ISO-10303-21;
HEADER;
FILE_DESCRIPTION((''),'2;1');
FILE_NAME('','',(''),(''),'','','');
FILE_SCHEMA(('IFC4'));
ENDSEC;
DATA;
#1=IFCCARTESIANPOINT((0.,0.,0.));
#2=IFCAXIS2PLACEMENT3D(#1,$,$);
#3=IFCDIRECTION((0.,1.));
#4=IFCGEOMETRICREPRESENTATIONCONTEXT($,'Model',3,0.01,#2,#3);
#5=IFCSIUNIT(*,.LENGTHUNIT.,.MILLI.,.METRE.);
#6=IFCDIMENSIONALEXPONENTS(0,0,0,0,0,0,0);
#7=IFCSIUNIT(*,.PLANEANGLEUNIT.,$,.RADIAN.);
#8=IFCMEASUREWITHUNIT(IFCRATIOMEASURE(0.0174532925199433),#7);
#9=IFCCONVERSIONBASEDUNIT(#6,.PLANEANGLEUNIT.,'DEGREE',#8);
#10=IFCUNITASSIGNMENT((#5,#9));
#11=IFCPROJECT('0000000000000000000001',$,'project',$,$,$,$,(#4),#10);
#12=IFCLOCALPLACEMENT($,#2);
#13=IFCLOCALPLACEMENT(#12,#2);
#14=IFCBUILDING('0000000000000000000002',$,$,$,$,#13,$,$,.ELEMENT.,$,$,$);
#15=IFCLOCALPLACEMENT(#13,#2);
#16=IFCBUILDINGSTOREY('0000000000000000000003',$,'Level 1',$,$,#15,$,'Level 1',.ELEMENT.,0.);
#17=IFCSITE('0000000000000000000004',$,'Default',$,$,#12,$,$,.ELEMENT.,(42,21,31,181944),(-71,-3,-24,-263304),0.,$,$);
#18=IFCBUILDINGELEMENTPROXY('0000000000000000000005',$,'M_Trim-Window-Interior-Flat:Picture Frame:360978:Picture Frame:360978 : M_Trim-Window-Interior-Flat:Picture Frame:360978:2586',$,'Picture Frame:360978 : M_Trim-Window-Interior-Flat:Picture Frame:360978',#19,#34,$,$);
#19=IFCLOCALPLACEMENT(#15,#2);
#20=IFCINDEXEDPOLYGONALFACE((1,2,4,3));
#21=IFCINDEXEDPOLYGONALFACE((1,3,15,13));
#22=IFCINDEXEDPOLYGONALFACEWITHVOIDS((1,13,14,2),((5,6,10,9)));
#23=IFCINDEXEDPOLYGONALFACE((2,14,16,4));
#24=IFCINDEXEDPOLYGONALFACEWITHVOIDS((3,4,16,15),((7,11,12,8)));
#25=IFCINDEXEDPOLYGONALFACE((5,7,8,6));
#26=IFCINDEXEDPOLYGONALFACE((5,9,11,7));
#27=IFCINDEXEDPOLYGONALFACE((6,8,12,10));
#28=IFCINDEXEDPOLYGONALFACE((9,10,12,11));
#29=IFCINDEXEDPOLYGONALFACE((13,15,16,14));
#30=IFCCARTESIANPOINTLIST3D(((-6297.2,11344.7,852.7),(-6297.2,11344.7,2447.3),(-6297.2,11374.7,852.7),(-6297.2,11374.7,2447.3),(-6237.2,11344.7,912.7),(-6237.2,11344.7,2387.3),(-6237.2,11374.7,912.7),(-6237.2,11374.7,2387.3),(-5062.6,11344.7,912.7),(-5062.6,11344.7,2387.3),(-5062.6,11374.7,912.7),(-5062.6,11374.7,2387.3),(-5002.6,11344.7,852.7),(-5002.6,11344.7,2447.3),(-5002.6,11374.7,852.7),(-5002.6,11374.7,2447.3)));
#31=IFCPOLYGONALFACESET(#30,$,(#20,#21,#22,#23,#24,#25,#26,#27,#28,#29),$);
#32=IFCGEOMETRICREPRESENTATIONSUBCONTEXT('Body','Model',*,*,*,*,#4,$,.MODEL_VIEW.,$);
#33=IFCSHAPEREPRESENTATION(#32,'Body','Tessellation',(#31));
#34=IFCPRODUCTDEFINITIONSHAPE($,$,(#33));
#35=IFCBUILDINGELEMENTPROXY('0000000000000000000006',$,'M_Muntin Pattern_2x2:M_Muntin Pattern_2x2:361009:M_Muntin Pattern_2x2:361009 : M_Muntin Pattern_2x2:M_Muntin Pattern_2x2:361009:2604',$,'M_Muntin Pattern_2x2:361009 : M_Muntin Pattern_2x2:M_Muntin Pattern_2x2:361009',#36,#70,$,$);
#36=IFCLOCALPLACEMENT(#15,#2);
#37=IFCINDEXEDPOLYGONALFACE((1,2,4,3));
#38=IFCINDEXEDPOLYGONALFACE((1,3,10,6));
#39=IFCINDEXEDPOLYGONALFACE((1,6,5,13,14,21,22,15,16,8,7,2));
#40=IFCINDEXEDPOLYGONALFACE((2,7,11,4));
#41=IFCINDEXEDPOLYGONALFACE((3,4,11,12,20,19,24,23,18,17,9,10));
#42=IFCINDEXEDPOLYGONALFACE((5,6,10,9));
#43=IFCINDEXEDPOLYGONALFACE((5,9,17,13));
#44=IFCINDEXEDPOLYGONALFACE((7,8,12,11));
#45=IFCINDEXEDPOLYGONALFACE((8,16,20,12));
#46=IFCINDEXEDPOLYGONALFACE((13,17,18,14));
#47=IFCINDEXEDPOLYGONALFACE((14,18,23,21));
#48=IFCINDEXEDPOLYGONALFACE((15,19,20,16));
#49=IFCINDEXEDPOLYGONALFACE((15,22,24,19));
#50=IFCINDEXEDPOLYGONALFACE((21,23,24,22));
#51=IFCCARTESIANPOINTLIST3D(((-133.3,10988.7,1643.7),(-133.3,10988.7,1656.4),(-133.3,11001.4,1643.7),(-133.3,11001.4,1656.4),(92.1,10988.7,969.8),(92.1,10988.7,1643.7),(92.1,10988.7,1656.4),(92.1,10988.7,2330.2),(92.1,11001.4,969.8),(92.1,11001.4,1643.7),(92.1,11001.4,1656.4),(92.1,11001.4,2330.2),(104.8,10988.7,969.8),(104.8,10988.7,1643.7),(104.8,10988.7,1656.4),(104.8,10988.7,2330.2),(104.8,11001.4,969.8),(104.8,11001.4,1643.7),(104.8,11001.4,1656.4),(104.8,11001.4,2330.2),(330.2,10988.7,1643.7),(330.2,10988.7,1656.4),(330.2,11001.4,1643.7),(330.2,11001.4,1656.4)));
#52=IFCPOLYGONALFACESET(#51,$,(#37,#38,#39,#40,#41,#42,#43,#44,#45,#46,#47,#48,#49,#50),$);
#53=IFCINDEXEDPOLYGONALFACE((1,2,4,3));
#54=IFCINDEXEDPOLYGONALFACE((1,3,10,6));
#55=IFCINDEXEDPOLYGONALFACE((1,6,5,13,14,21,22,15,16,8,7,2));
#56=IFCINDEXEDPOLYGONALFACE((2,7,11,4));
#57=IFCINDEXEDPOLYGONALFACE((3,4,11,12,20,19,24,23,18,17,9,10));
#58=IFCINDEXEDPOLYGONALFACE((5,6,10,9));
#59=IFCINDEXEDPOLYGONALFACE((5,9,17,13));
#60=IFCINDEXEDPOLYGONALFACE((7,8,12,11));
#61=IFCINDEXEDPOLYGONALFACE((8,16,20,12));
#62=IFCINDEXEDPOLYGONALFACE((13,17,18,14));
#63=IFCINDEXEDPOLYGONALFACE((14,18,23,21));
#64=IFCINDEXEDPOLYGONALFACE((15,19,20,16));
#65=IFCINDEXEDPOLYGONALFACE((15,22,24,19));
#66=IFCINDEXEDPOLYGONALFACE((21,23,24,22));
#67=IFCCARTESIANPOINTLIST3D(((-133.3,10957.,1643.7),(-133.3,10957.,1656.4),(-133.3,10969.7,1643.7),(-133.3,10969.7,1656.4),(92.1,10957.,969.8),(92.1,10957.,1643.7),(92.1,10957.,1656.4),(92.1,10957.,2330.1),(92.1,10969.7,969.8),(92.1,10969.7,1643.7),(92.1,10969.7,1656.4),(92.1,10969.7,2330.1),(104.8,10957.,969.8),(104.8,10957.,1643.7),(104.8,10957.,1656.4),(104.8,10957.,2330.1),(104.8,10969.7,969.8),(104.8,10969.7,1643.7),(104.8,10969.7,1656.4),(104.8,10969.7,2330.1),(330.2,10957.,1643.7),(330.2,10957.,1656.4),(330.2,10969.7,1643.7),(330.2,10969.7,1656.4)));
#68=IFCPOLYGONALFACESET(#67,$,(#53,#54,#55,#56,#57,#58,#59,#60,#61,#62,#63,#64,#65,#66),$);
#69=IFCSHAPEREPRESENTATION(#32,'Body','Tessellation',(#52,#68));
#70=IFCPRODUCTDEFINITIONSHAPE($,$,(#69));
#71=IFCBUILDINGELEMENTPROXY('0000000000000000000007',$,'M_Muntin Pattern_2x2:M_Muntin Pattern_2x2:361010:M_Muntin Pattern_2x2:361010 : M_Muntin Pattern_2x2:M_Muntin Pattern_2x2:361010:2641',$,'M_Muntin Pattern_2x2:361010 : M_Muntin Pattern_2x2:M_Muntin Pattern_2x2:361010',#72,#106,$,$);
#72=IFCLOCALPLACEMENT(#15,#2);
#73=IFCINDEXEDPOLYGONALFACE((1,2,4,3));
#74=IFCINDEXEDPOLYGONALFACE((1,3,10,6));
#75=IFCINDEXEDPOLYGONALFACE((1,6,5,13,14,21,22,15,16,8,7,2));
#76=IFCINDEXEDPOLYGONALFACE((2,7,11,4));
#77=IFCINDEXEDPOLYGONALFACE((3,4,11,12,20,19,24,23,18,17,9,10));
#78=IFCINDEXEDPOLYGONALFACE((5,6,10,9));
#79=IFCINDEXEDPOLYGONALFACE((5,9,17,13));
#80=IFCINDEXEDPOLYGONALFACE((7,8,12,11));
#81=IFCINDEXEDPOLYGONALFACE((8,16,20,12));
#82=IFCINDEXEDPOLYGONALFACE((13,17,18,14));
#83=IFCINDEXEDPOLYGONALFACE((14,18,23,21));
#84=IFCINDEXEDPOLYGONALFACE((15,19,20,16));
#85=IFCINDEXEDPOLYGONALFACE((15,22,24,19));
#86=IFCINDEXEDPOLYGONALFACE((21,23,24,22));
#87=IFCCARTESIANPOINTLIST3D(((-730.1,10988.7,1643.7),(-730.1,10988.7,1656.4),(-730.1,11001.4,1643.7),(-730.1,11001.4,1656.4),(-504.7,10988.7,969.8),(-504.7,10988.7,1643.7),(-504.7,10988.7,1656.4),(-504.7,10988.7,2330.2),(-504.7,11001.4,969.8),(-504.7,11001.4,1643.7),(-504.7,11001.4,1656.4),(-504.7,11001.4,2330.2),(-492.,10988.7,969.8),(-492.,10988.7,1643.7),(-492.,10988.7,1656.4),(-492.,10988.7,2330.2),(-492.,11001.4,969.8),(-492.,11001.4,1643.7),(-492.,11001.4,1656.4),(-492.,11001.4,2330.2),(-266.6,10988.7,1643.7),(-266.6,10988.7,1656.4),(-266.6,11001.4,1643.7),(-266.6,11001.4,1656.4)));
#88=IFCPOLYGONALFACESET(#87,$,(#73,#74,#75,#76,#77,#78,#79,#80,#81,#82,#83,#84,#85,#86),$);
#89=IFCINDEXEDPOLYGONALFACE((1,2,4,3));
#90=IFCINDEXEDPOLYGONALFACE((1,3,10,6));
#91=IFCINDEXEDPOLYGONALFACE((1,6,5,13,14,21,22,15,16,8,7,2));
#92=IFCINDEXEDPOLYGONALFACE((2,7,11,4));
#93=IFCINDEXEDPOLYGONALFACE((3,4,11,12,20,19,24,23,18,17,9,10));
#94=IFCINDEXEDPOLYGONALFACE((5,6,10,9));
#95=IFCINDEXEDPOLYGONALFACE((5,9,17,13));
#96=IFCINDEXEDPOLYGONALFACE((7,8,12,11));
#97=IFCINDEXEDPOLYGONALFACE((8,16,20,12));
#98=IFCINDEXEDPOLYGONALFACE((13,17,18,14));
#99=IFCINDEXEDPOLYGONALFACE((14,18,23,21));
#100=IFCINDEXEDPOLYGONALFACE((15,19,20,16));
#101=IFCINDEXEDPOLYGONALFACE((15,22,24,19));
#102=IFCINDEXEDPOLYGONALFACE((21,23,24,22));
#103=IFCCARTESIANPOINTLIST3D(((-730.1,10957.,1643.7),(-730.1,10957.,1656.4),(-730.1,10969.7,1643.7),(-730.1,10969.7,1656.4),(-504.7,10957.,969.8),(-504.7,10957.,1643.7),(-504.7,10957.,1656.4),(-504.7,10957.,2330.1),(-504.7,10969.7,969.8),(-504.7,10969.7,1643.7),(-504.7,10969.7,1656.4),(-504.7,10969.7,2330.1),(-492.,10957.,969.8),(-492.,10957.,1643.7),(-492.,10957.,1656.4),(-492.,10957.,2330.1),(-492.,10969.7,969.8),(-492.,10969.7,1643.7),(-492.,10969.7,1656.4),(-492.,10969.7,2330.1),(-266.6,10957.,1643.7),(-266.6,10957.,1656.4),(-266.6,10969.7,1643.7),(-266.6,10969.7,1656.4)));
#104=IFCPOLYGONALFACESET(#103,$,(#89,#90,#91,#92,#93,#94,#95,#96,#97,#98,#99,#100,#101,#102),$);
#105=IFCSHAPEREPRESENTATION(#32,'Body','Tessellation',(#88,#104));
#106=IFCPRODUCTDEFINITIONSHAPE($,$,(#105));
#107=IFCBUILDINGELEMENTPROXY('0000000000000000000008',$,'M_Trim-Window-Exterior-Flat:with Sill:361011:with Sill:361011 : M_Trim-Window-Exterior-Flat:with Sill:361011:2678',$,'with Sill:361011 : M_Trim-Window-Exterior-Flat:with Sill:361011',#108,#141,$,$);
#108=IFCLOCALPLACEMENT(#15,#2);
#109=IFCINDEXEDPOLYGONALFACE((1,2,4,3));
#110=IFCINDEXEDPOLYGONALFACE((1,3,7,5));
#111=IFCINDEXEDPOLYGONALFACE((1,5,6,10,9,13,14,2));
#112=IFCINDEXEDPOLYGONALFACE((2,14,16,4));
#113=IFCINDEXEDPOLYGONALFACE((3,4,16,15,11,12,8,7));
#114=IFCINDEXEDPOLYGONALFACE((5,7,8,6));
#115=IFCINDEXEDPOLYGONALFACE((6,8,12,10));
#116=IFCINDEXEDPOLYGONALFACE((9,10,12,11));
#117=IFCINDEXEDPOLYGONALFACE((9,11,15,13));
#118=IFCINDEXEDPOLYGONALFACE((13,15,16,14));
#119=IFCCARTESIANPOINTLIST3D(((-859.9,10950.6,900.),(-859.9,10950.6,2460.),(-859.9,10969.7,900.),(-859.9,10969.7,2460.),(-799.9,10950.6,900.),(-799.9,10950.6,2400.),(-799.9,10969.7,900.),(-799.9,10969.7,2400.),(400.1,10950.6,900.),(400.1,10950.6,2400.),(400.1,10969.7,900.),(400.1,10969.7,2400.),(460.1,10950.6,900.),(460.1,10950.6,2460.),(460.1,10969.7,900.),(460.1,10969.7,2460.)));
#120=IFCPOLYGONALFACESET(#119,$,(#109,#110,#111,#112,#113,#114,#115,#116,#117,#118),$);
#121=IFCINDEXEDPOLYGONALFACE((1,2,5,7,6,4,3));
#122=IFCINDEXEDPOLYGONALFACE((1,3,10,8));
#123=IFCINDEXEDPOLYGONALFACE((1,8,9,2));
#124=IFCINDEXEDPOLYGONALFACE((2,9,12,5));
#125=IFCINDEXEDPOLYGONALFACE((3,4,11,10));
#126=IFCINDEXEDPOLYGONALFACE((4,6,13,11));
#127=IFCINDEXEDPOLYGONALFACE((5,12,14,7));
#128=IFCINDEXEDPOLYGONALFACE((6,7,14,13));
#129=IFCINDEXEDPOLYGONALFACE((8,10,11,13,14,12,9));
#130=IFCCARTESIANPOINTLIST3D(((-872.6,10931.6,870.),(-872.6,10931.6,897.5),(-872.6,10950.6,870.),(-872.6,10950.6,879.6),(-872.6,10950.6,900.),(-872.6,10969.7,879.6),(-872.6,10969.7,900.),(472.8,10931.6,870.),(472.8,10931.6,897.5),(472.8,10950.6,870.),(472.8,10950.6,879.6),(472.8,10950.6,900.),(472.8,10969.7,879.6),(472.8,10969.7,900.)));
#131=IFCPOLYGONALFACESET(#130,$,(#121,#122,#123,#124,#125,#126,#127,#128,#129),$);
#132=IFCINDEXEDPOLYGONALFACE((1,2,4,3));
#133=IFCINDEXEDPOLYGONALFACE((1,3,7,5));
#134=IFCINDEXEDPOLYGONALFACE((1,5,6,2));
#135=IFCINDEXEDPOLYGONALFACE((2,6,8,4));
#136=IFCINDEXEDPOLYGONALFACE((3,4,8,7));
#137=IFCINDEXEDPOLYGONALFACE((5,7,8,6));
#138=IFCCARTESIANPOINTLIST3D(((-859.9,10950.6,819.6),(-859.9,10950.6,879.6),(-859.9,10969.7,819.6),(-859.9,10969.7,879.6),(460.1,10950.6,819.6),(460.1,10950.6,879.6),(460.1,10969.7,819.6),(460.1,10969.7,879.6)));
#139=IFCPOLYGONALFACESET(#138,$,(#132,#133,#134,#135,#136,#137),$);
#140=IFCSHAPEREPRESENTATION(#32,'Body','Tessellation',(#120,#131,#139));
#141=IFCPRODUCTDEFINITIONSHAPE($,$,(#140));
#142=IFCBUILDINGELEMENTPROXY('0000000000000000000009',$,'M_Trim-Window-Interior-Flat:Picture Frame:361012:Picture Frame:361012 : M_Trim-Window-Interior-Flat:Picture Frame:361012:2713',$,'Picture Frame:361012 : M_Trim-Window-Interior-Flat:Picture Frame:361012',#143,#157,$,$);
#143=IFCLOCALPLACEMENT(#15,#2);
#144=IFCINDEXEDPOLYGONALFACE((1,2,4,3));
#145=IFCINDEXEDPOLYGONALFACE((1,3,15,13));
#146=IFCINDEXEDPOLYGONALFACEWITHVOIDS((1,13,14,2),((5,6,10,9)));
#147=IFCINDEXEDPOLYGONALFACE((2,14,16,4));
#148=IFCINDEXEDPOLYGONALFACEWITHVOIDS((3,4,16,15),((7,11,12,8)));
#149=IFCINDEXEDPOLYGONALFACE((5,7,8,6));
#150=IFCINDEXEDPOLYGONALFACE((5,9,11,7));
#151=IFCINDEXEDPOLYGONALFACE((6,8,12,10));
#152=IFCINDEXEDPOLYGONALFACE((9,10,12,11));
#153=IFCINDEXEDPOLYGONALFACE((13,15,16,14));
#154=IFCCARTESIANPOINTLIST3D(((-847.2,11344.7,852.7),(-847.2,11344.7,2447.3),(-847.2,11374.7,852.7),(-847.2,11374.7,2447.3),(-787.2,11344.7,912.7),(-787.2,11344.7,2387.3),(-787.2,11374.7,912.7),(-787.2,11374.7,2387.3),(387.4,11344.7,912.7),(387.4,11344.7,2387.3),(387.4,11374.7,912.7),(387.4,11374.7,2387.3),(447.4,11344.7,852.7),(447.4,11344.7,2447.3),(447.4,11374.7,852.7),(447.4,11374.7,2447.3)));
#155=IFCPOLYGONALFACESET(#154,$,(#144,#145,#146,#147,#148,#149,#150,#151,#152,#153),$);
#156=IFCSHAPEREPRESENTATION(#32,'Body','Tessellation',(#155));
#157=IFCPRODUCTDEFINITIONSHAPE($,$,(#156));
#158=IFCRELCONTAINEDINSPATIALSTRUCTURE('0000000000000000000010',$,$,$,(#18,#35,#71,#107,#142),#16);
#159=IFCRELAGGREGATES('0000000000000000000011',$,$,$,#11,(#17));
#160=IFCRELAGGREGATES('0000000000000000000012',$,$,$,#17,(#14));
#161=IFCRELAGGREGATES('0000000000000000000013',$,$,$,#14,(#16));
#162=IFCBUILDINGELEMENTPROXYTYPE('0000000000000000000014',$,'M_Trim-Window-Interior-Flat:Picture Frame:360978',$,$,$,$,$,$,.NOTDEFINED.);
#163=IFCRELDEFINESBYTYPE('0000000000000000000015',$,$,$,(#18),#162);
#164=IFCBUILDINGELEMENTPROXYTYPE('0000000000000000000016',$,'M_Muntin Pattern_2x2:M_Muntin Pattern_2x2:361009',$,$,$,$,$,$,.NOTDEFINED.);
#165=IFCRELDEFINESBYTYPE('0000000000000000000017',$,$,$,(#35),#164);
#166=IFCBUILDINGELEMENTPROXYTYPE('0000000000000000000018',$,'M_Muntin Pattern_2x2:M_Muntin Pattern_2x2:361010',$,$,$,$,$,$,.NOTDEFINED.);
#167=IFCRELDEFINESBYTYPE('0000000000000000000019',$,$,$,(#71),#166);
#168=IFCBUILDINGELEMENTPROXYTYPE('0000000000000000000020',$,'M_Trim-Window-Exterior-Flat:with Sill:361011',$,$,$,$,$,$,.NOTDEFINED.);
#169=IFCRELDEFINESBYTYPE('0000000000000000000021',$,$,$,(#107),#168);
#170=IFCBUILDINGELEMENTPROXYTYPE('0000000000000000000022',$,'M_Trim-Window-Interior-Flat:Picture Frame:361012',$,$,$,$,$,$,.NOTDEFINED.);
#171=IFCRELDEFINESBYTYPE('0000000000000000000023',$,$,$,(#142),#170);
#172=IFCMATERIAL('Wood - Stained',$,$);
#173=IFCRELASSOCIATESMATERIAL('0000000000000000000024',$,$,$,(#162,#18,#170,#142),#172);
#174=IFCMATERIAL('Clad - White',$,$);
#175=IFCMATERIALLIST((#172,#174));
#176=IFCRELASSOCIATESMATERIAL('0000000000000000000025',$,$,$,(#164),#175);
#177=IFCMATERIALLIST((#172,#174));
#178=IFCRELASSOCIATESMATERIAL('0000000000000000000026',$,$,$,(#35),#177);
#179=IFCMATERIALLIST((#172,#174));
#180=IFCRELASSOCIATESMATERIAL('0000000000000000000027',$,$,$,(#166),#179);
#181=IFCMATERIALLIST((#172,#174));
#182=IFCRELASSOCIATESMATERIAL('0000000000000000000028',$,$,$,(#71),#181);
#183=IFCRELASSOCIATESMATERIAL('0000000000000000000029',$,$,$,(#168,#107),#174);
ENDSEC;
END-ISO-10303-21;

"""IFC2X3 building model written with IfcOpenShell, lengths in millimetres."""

from ifc_helpers import new_model, entity, si_unit, converted_unit, direction, frame, origin, origin_2d_with_axis, place, context, subcontext, project, spatial, polyline, rectangle, outline, extrude, source, transform, mapped, material, material_list, type_object, type_shapes, element, save


model = new_model("IFC2X3")

# Units and contexts
model_context = context("Model", 3, precision=0.01, world=origin(), true_north=direction((0.0, 1.0)))
body_context = subcontext(model_context, "Body", "Model", "MODEL_VIEW")
ifc_project = project(units=[si_unit("LENGTHUNIT", "METRE", prefix="MILLI"), converted_unit("PLANEANGLEUNIT", "DEGREE", entity("IfcRatioMeasure", 0.0174532925199433), si_unit("PLANEANGLEUNIT", "RADIAN"), dimensions=[0, 0, 0, 0, 0, 0, 0])], contexts=[model_context])

# Site, building, storey
site_placement = place(None, origin())
site = spatial("IfcSite", under=ifc_project, at=site_placement, Name="Default", CompositionType="ELEMENT", RefLatitude=(42, 21, 31, 181944), RefLongitude=(-71, -3, -24, -263304), RefElevation=0.0)
building_placement = place(site_placement, origin())
building = spatial("IfcBuilding", under=site, at=building_placement, CompositionType="ELEMENT")
storey_placement = place(building_placement, origin())
storey = spatial("IfcBuildingStorey", under=building, at=storey_placement, Name="Level 1", LongName="Level 1", CompositionType="ELEMENT", Elevation=0.0)

# Building element proxies
ifc_material_1 = material(Name="Wood - Stained")
ifc_material_2 = material(Name="Clad - White")
building_element_proxy_type_1 = type_object("IfcBuildingElementProxyType", Name="M_Trim-Window-Interior-Flat:Picture Frame:360978", PredefinedType="NOTDEFINED", material=ifc_material_1)
shared_shape_1 = source(origin(), body_context, "Body", "SweptSolid", [
    extrude(outline(polyline([(-797.3, -647.3), (797.3, -647.3), (797.3, 647.3), (-797.3, 647.3), (-797.3, -647.3)]), holes=[polyline([(737.3, 587.3), (737.3, -587.3), (-737.3, -587.3), (-737.3, 587.3), (737.3, 587.3)])]), frame((-5649.9, 11344.7, 1650.0), z_axis=(0.0, 1.0, 0.0), x_axis=(0.0, 0.0, -1.0)), (0.0, 0.0, 1.0), 30.0),
])
type_shapes(building_element_proxy_type_1, [shared_shape_1])
proxy_1_placement = place(storey_placement, origin())
element("IfcBuildingElementProxy", 1, at=proxy_1_placement, inside=storey, type_object=building_element_proxy_type_1, material=ifc_material_1, Name="M_Trim-Window-Interior-Flat:Picture Frame:360978:Picture Frame:360978 : M_Trim-Window-Interior-Flat:Picture Frame:360978:2586", ObjectType="Picture Frame:360978 : M_Trim-Window-Interior-Flat:Picture Frame:360978", context=body_context, shape_type="MappedRepresentation", body=[
    mapped(shared_shape_1, transform((0.0, 0.0, 0.0), scale=1.0)),
])
ifc_material_list_1 = material_list([ifc_material_1, ifc_material_2])
ifc_material_list_2 = material_list([ifc_material_1, ifc_material_2])
building_element_proxy_type_2 = type_object("IfcBuildingElementProxyType", Name="M_Muntin Pattern_2x2:M_Muntin Pattern_2x2:361009", PredefinedType="NOTDEFINED", material=ifc_material_list_2)
shared_shape_2 = source(origin(), body_context, "Body", "SweptSolid", [
    extrude(outline(polyline([(-680.2, 6.4), (-680.2, -6.3), (-6.4, -6.3), (-6.4, -231.7), (6.3, -231.7), (6.3, -6.3), (680.2, -6.3), (680.2, 6.4), (6.3, 6.4), (6.3, 231.7), (-6.4, 231.7), (-6.4, 6.4), (-680.2, 6.4)])), frame((98.5, 10988.7, 1650.0), z_axis=(0.0, -1.0, 0.0), x_axis=(0.0, 0.0, -1.0)), (0.0, 0.0, -1.0), 12.7),
    extrude(outline(polyline([(-680.1, 6.4), (-680.1, -6.3), (-6.4, -6.3), (-6.4, -231.7), (6.3, -231.7), (6.3, -6.3), (680.2, -6.3), (680.2, 6.4), (6.3, 6.4), (6.3, 231.7), (-6.4, 231.7), (-6.4, 6.4), (-680.1, 6.4)])), frame((98.5, 10957.0, 1650.0), z_axis=(0.0, -1.0, 0.0), x_axis=(0.0, 0.0, -1.0)), (0.0, 0.0, -1.0), 12.7),
])
type_shapes(building_element_proxy_type_2, [shared_shape_2])
proxy_2_placement = place(storey_placement, origin())
element("IfcBuildingElementProxy", 2, at=proxy_2_placement, inside=storey, type_object=building_element_proxy_type_2, material=ifc_material_list_1, Name="M_Muntin Pattern_2x2:M_Muntin Pattern_2x2:361009:M_Muntin Pattern_2x2:361009 : M_Muntin Pattern_2x2:M_Muntin Pattern_2x2:361009:2604", ObjectType="M_Muntin Pattern_2x2:361009 : M_Muntin Pattern_2x2:M_Muntin Pattern_2x2:361009", context=body_context, shape_type="MappedRepresentation", body=[
    mapped(shared_shape_2, transform((0.0, 0.0, 0.0), scale=1.0)),
])
ifc_material_list_3 = material_list([ifc_material_1, ifc_material_2])
ifc_material_list_4 = material_list([ifc_material_1, ifc_material_2])
building_element_proxy_type_3 = type_object("IfcBuildingElementProxyType", Name="M_Muntin Pattern_2x2:M_Muntin Pattern_2x2:361010", PredefinedType="NOTDEFINED", material=ifc_material_list_4)
shared_shape_3 = source(origin(), body_context, "Body", "SweptSolid", [
    extrude(outline(polyline([(-6.4, -680.1), (6.3, -680.1), (6.3, -6.4), (231.7, -6.4), (231.7, 6.3), (6.3, 6.3), (6.3, 680.2), (-6.4, 680.2), (-6.4, 6.3), (-231.7, 6.3), (-231.7, -6.4), (-6.4, -6.4), (-6.4, -680.1)])), frame((-498.4, 10988.7, 1650.0), z_axis=(0.0, 1.0, 0.0), x_axis=(1.0, 0.0, 0.0)), (0.0, 0.0, 1.0), 12.7),
    extrude(outline(polyline([(-6.4, -680.1), (6.3, -680.1), (6.3, -6.4), (231.7, -6.4), (231.7, 6.3), (6.3, 6.3), (6.3, 680.2), (-6.4, 680.2), (-6.4, 6.3), (-231.7, 6.3), (-231.7, -6.4), (-6.4, -6.4), (-6.4, -680.1)])), frame((-498.4, 10957.0, 1650.0), z_axis=(0.0, 1.0, 0.0), x_axis=(1.0, 0.0, 0.0)), (0.0, 0.0, 1.0), 12.7),
])
type_shapes(building_element_proxy_type_3, [shared_shape_3])
proxy_3_placement = place(storey_placement, origin())
element("IfcBuildingElementProxy", 3, at=proxy_3_placement, inside=storey, type_object=building_element_proxy_type_3, material=ifc_material_list_3, Name="M_Muntin Pattern_2x2:M_Muntin Pattern_2x2:361010:M_Muntin Pattern_2x2:361010 : M_Muntin Pattern_2x2:M_Muntin Pattern_2x2:361010:2641", ObjectType="M_Muntin Pattern_2x2:361010 : M_Muntin Pattern_2x2:M_Muntin Pattern_2x2:361010", context=body_context, shape_type="MappedRepresentation", body=[
    mapped(shared_shape_3, transform((0.0, 0.0, 0.0), scale=1.0)),
])
building_element_proxy_type_4 = type_object("IfcBuildingElementProxyType", Name="M_Trim-Window-Exterior-Flat:with Sill:361011", PredefinedType="NOTDEFINED", material=ifc_material_2)
shared_shape_4 = source(origin(), body_context, "Body", "SweptSolid", [
    extrude(outline(polyline([(-765.0, -660.0), (795.0, -660.0), (795.0, 660.0), (-765.0, 660.0), (-765.0, 600.0), (735.0, 600.0), (735.0, -600.0), (-765.0, -600.0), (-765.0, -660.0)])), frame((-199.9, 10950.6, 1665.0), z_axis=(0.0, 1.0, 0.0), x_axis=(0.0, 0.0, 1.0)), (0.0, 0.0, 1.0), 19.1),
    extrude(outline(polyline([(-15.2, 0.0), (-15.2, -19.0), (12.3, -19.0), (14.8, 0.0), (14.8, 19.0), (-5.7, 19.0), (-5.7, 0.0), (-15.2, 0.0)])), frame((-872.6, 10950.6, 885.2), z_axis=(-1.0, 0.0, 0.0), x_axis=(0.0, 0.0, 1.0)), (0.0, 0.0, -1.0), 1345.4),
    extrude(rectangle(XDim=19.1, YDim=1320.0, at=origin_2d_with_axis()), frame((-199.9, 10960.1, 819.6), z_axis=(0.0, 0.0, 1.0), x_axis=(0.0, 1.0, 0.0)), (0.0, 0.0, 1.0), 60.0),
])
type_shapes(building_element_proxy_type_4, [shared_shape_4])
proxy_4_placement = place(storey_placement, origin())
element("IfcBuildingElementProxy", 4, at=proxy_4_placement, inside=storey, type_object=building_element_proxy_type_4, material=ifc_material_2, Name="M_Trim-Window-Exterior-Flat:with Sill:361011:with Sill:361011 : M_Trim-Window-Exterior-Flat:with Sill:361011:2678", ObjectType="with Sill:361011 : M_Trim-Window-Exterior-Flat:with Sill:361011", context=body_context, shape_type="MappedRepresentation", body=[
    mapped(shared_shape_4, transform((0.0, 0.0, 0.0), scale=1.0)),
])
building_element_proxy_type_5 = type_object("IfcBuildingElementProxyType", Name="M_Trim-Window-Interior-Flat:Picture Frame:361012", PredefinedType="NOTDEFINED", material=ifc_material_1)
shared_shape_5 = source(origin(), body_context, "Body", "SweptSolid", [
    extrude(outline(polyline([(-797.3, -647.3), (797.3, -647.3), (797.3, 647.3), (-797.3, 647.3), (-797.3, -647.3)]), holes=[polyline([(737.3, 587.3), (737.3, -587.3), (-737.3, -587.3), (-737.3, 587.3), (737.3, 587.3)])]), frame((-199.9, 11344.7, 1650.0), z_axis=(0.0, 1.0, 0.0), x_axis=(0.0, 0.0, -1.0)), (0.0, 0.0, 1.0), 30.0),
])
type_shapes(building_element_proxy_type_5, [shared_shape_5])
proxy_5_placement = place(storey_placement, origin())
element("IfcBuildingElementProxy", 5, at=proxy_5_placement, inside=storey, type_object=building_element_proxy_type_5, material=ifc_material_1, Name="M_Trim-Window-Interior-Flat:Picture Frame:361012:Picture Frame:361012 : M_Trim-Window-Interior-Flat:Picture Frame:361012:2713", ObjectType="Picture Frame:361012 : M_Trim-Window-Interior-Flat:Picture Frame:361012", context=body_context, shape_type="MappedRepresentation", body=[
    mapped(shared_shape_5, transform((0.0, 0.0, 0.0), scale=1.0)),
])

save(model, "model.ifc")
